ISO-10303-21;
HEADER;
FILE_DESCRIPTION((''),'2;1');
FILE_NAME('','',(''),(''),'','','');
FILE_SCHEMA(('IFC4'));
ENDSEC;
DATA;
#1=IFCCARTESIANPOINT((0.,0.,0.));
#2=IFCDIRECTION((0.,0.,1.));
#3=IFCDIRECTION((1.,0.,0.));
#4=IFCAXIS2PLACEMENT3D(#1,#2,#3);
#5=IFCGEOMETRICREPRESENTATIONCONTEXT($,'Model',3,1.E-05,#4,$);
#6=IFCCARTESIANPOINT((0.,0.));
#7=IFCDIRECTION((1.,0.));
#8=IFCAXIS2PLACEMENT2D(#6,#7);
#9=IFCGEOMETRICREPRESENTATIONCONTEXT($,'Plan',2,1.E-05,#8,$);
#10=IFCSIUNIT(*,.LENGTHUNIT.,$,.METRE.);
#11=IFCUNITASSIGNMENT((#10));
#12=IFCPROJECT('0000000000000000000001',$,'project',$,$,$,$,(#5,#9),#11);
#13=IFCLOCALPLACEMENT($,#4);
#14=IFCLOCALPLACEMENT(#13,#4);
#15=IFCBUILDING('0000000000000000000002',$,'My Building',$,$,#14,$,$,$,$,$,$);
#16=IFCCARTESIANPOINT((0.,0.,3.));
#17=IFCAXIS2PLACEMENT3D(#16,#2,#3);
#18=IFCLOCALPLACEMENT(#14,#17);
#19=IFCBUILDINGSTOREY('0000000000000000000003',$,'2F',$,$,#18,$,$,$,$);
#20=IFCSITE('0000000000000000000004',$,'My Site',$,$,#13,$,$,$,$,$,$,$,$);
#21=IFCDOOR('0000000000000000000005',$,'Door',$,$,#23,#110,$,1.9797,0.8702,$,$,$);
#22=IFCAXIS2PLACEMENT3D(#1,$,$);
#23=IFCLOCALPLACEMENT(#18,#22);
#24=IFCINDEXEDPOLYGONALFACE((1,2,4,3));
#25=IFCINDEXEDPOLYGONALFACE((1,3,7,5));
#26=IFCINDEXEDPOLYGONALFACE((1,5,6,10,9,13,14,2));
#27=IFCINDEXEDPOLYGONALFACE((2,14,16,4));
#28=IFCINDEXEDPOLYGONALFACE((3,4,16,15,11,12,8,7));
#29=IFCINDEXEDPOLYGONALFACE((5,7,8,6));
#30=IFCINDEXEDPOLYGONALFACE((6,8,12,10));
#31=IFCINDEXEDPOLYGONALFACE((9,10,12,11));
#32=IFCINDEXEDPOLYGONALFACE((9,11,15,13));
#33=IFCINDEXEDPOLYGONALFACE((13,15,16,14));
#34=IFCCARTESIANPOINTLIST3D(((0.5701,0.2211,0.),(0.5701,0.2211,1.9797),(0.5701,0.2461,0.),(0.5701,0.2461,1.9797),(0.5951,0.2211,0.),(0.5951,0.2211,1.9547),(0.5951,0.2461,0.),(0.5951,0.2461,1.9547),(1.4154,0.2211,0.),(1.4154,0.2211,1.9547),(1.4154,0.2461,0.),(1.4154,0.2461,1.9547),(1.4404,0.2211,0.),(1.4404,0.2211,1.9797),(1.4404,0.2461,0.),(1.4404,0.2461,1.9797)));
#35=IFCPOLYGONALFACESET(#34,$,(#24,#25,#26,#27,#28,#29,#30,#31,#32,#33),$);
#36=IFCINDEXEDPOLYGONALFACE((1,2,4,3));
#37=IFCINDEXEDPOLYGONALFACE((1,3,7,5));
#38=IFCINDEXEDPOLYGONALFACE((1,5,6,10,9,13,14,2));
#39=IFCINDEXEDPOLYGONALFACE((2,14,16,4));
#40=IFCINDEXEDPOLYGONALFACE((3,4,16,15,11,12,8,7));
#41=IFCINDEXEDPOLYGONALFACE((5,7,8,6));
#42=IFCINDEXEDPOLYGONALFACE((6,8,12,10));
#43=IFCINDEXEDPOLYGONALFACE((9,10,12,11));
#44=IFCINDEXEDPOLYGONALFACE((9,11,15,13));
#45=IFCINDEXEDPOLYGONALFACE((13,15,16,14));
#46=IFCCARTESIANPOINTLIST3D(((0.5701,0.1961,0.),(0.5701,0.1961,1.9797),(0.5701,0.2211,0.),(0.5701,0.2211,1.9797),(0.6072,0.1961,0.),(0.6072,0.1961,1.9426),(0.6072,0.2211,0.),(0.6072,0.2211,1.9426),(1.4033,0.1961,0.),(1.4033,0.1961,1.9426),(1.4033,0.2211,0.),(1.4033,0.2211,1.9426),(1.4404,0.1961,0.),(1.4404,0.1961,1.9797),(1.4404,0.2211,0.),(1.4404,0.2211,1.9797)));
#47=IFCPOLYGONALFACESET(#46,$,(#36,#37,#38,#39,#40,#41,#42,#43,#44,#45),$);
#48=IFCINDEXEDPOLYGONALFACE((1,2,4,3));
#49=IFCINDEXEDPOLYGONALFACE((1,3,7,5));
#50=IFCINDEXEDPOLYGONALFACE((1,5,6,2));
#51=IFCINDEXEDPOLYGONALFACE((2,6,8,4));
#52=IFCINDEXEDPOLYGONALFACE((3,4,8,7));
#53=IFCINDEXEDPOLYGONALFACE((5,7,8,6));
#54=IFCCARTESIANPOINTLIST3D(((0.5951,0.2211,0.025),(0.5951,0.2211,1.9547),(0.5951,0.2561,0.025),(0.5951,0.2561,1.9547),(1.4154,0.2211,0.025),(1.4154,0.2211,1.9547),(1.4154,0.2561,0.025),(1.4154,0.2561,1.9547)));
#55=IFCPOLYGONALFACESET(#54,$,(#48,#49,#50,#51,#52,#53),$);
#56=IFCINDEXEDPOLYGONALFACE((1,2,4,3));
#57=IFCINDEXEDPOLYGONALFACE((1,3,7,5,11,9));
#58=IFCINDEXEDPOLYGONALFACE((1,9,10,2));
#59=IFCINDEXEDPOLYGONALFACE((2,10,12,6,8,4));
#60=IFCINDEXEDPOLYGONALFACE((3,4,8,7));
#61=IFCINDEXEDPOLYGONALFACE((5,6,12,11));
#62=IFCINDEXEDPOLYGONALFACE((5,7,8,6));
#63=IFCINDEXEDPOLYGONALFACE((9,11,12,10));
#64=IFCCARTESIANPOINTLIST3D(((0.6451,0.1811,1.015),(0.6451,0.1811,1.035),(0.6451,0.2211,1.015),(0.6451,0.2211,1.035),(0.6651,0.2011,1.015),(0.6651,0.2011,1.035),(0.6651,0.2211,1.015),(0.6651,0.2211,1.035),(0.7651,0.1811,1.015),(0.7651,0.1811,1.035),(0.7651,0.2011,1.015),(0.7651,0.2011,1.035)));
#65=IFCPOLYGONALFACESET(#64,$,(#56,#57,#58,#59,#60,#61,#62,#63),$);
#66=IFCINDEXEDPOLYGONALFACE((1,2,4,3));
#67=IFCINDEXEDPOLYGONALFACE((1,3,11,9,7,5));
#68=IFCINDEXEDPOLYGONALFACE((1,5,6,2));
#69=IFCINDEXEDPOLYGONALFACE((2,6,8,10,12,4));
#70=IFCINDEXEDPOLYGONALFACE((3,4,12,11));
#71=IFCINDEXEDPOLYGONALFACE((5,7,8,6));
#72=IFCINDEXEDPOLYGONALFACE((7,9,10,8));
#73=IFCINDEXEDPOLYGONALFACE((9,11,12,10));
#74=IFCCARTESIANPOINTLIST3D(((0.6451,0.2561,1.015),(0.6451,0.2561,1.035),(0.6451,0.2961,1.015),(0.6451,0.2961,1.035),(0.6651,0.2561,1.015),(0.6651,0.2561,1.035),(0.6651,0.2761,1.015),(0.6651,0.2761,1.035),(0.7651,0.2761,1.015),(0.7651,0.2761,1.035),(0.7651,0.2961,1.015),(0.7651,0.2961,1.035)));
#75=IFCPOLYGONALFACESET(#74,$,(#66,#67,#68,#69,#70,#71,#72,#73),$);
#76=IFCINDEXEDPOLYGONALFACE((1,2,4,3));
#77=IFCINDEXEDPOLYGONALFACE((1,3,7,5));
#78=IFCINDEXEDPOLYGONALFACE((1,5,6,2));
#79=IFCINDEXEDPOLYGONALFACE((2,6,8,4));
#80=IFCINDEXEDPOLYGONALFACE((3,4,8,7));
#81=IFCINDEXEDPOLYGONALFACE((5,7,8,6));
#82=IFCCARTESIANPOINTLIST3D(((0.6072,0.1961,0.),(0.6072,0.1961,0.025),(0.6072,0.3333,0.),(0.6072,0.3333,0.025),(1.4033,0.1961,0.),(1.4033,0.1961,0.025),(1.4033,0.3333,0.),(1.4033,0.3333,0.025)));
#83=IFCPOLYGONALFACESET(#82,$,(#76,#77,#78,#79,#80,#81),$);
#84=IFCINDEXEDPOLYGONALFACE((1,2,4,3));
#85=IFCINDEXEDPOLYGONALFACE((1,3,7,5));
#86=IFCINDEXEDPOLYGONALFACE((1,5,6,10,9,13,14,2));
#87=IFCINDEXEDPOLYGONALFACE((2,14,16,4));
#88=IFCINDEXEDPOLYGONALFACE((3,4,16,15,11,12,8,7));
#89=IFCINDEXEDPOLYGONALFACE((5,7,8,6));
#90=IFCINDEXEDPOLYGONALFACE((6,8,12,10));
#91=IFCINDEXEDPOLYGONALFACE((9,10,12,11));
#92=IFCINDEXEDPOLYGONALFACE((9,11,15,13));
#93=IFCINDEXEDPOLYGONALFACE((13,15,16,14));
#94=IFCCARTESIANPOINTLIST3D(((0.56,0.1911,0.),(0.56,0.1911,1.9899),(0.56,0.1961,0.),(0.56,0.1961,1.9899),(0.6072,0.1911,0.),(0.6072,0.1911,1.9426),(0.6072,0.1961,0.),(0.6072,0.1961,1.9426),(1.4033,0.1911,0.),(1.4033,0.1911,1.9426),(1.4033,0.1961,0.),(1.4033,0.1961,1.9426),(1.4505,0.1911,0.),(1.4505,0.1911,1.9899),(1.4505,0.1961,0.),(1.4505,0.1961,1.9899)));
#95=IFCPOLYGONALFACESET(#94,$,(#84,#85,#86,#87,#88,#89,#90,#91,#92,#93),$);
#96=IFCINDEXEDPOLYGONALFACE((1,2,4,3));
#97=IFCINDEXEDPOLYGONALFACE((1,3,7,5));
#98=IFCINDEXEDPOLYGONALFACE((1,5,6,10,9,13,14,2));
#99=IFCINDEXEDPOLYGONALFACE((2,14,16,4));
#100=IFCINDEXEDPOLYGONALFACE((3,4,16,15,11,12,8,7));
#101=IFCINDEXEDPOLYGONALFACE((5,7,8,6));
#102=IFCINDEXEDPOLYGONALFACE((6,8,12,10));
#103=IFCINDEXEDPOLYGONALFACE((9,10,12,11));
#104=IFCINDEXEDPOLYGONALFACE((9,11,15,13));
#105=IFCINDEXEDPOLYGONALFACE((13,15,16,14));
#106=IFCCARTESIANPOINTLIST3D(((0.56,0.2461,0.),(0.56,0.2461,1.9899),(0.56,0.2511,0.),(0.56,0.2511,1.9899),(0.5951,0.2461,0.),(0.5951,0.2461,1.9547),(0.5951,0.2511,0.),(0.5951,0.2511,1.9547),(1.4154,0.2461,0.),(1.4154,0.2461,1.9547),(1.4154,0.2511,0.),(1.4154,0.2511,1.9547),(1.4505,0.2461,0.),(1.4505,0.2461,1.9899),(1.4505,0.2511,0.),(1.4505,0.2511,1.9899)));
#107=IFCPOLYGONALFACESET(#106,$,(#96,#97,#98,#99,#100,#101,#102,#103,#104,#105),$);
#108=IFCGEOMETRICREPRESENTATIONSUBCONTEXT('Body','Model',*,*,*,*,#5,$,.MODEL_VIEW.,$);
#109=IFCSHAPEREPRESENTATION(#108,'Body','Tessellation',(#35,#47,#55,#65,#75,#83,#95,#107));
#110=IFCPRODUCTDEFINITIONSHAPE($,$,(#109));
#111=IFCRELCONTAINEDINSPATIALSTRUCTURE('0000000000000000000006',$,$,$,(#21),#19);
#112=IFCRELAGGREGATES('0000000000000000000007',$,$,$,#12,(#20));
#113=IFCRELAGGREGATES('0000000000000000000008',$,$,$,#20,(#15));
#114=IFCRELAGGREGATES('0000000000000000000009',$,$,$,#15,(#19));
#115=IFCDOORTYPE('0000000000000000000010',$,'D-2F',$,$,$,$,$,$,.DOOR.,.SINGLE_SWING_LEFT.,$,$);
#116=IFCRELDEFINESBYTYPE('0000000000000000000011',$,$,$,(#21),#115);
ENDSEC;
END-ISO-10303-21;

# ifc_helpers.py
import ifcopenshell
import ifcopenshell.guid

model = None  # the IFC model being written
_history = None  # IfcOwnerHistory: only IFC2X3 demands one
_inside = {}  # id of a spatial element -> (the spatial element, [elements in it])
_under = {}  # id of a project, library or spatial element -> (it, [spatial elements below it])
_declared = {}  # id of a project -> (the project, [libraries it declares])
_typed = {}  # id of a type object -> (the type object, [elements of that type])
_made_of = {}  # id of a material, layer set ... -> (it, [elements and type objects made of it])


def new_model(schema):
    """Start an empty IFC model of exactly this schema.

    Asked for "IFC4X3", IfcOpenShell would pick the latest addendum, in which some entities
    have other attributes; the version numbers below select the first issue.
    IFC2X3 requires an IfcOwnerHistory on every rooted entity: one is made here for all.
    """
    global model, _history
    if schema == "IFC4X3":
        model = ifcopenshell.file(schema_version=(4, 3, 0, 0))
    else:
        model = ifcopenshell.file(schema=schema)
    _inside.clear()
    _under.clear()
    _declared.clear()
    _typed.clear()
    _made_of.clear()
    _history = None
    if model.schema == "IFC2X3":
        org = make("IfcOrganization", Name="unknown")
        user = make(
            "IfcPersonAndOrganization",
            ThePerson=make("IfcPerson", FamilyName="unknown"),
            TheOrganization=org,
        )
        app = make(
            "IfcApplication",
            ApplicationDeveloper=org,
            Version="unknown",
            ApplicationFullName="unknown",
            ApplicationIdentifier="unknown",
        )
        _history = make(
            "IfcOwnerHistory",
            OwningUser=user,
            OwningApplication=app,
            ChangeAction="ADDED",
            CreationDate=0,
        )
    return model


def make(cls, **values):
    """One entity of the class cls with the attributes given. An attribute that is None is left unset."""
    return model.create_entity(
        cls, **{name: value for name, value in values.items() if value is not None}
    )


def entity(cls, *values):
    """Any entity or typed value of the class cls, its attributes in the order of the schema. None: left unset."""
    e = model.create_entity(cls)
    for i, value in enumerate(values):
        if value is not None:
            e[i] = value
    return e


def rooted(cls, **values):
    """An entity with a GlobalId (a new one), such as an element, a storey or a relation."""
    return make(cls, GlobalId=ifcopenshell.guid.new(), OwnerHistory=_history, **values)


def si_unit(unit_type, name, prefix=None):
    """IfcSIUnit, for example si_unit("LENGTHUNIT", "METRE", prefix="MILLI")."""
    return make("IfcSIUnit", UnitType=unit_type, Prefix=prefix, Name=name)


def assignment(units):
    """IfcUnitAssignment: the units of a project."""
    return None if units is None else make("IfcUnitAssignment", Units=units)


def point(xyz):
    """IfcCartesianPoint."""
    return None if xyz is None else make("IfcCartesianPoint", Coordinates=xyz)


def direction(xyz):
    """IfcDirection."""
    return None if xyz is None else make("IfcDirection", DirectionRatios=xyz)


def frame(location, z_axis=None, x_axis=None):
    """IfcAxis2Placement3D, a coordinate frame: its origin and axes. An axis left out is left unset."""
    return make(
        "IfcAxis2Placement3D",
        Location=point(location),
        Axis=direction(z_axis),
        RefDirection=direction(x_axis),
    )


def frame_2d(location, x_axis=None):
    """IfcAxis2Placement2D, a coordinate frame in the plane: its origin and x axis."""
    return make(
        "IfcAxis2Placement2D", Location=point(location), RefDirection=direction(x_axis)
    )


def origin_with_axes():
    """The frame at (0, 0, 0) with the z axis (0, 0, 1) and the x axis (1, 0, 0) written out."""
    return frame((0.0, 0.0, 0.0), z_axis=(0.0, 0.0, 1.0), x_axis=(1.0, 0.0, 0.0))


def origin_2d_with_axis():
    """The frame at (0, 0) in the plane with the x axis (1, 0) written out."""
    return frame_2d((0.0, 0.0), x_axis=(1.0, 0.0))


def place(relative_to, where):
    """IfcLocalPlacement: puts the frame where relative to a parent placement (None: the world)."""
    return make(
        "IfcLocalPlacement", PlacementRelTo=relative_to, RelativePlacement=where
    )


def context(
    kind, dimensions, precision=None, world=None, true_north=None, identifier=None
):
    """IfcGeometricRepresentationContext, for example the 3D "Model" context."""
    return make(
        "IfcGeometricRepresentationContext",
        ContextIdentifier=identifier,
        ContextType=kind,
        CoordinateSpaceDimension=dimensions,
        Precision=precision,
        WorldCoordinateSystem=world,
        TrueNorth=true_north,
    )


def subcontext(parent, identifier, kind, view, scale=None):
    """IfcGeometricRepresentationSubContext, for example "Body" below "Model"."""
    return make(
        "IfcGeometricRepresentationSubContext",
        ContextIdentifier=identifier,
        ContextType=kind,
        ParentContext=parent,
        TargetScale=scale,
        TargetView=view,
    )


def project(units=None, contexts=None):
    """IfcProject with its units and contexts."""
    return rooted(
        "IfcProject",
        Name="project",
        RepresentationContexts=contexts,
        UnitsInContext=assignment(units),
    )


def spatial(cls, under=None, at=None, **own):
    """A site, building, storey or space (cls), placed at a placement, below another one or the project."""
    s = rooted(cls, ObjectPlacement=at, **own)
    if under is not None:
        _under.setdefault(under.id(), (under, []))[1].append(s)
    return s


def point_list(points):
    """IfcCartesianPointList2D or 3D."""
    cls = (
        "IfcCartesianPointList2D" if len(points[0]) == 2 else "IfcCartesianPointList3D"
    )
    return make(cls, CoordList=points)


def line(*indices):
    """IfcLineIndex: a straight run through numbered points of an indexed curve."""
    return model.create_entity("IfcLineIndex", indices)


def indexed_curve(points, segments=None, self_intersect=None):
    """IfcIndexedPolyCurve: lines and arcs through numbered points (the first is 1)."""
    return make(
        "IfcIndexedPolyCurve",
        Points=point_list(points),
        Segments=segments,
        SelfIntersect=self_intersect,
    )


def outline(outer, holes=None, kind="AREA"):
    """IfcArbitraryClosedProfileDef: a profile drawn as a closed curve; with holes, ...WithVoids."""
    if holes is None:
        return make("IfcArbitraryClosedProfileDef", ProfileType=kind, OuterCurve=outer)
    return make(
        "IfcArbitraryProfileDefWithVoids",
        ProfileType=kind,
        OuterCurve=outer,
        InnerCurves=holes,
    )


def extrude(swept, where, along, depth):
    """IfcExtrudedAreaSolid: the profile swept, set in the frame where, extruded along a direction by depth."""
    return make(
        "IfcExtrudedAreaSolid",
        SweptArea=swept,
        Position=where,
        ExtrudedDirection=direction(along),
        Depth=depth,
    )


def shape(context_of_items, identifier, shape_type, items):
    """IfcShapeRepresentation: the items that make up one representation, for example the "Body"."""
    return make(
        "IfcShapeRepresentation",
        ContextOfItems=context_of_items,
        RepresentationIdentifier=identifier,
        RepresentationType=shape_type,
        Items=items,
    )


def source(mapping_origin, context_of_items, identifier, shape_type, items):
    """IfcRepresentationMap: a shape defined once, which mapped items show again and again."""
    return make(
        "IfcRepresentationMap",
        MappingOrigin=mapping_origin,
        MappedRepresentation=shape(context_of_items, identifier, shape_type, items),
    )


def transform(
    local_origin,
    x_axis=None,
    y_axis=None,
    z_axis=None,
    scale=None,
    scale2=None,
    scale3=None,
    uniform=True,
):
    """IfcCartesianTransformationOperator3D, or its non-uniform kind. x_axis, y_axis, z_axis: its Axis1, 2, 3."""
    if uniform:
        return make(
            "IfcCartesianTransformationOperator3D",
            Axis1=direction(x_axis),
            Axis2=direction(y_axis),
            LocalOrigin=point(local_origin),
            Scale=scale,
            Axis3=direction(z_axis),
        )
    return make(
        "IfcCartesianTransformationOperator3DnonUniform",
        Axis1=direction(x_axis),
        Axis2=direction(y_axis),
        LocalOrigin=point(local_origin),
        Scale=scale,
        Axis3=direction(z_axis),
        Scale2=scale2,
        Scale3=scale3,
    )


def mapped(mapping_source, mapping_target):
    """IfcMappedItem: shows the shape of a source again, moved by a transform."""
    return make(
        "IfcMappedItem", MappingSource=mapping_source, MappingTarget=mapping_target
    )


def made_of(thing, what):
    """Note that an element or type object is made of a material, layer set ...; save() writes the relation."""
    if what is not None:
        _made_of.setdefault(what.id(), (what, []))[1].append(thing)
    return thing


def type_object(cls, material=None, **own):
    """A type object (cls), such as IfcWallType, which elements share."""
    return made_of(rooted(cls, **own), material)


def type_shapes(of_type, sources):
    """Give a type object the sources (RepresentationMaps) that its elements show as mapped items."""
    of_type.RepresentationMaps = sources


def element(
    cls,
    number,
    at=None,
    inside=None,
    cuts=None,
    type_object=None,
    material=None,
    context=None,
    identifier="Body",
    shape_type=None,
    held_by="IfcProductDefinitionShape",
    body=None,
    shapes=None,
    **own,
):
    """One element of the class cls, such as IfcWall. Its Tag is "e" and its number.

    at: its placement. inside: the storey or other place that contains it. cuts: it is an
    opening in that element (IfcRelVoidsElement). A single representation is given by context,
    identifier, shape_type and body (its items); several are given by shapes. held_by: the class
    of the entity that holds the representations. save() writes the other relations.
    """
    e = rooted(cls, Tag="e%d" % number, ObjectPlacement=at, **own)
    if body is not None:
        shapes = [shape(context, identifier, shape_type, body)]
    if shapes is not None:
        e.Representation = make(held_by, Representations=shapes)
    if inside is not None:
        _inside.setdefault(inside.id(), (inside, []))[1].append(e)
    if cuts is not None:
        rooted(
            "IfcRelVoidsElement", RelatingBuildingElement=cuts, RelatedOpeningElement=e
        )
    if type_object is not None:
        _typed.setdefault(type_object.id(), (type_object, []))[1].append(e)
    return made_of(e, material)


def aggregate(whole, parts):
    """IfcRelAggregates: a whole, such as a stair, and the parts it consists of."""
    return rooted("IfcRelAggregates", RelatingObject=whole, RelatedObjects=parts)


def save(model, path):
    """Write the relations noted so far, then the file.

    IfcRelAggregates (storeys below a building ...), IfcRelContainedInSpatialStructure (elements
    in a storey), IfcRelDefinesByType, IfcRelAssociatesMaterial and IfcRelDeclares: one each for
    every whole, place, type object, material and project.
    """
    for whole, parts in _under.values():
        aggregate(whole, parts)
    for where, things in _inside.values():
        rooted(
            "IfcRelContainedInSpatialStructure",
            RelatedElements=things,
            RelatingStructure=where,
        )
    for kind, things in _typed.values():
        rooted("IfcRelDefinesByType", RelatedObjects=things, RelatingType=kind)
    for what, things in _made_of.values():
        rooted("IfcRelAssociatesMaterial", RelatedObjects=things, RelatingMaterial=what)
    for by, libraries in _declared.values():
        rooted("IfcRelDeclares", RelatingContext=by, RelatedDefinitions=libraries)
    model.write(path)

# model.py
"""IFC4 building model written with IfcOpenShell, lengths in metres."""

from ifc_helpers import new_model, entity, si_unit, frame, origin_with_axes, origin_2d_with_axis, place, context, subcontext, project, spatial, line, indexed_curve, outline, extrude, shape, source, transform, mapped, type_object, type_shapes, element, save


model = new_model("IFC4")

# Units and contexts
model_context = context("Model", 3, precision=1e-05, world=origin_with_axes())
plan_context = context("Plan", 2, precision=1e-05, world=origin_2d_with_axis())
body_context_1 = subcontext(model_context, "Body", "Model", "MODEL_VIEW")
body_context_2 = subcontext(plan_context, "Body", "Plan", "PLAN_VIEW")
ifc_project = project(units=[si_unit("LENGTHUNIT", "METRE")], contexts=[model_context, plan_context])

# Site, building, storey
site_placement = place(None, origin_with_axes())
site = spatial("IfcSite", under=ifc_project, at=site_placement, Name="My Site")
building_placement = place(site_placement, origin_with_axes())
building = spatial("IfcBuilding", under=site, at=building_placement, Name="My Building")
storey_placement = place(building_placement, frame((0.0, 0.0, 3.0), z_axis=(0.0, 0.0, 1.0), x_axis=(1.0, 0.0, 0.0)))
storey = spatial("IfcBuildingStorey", under=building, at=storey_placement, Name="2F")

# Shared definitions
door_type_1 = type_object("IfcDoorType", Name="D-2F", OperationType="SINGLE_SWING_LEFT", PredefinedType="DOOR")
shared_shape_1 = source(origin_with_axes(), body_context_1, "Body", "SweptSolid", [
    extrude(outline(indexed_curve([(0.0, 0.0), (0.0, 1.9797), (0.8702, 1.9797), (0.8702, 0.0), (0.8452, 0.0), (0.8452, 1.9547), (0.025, 1.9547), (0.025, 0.0)], segments=[line(1, 2, 3, 4, 5, 6, 7, 8, 1)])), frame((0.0, 0.025, 0.0), z_axis=(0.0, -1.0, 0.0), x_axis=(1.0, 0.0, 0.0)), (0.0, 0.0, -1.0), 0.025),
    extrude(outline(indexed_curve([(0.0, 0.0), (0.0, 1.9797), (0.8702, 1.9797), (0.8702, 0.0), (0.8332, 0.0), (0.8332, 1.9426), (0.0371, 1.9426), (0.0371, 0.0)], segments=[line(1, 2, 3, 4, 5, 6, 7, 8, 1)])), frame((0.0, 0.0, 0.0), z_axis=(0.0, -1.0, 0.0), x_axis=(1.0, 0.0, 0.0)), (0.0, 0.0, -1.0), 0.025),
    extrude(outline(indexed_curve([(0.0, 0.0), (0.8202, 0.0), (0.8202, 0.035), (0.0, 0.035)], segments=[line(1, 2, 3, 4, 1)])), frame((0.025, 0.025, 0.025), z_axis=(0.0, 0.0, 1.0), x_axis=(1.0, 0.0, 0.0)), (0.0, 0.0, 1.0), 1.9297),
    extrude(outline(indexed_curve([(0.0, 0.0), (0.0, -0.04), (0.12, -0.04), (0.12, -0.02), (0.02, -0.02), (0.02, 0.0)], segments=[line(1, 2, 3, 4, 5, 6, 1)])), frame((0.075, 0.025, 1.015), z_axis=(0.0, 0.0, 1.0), x_axis=(1.0, 0.0, 0.0)), (0.0, 0.0, 1.0), 0.02),
    extrude(outline(indexed_curve([(0.0, 0.0), (0.0, 0.04), (0.12, 0.04), (0.12, 0.02), (0.02, 0.02), (0.02, 0.0)], segments=[line(1, 2, 3, 4, 5, 6, 1)])), frame((0.075, 0.06, 1.015), z_axis=(0.0, 0.0, 1.0), x_axis=(1.0, 0.0, 0.0)), (0.0, 0.0, 1.0), 0.02),
    extrude(outline(indexed_curve([(0.0, 0.0), (0.7961, 0.0), (0.7961, 0.1372), (0.0, 0.1372)], segments=[line(1, 2, 3, 4, 1)])), frame((0.0371, 0.0, 0.0), z_axis=(0.0, 0.0, 1.0), x_axis=(1.0, 0.0, 0.0)), (0.0, 0.0, 1.0), 0.025),
    extrude(outline(indexed_curve([(0.0, 0.0), (0.0, 1.9899), (0.8906, 1.9899), (0.8906, 0.0), (0.8433, 0.0), (0.8433, 1.9426), (0.0473, 1.9426), (0.0473, 0.0)], segments=[line(1, 2, 3, 4, 5, 6, 7, 8, 1)])), frame((-0.0102, -0.005, 0.0), z_axis=(0.0, -1.0, 0.0), x_axis=(1.0, 0.0, 0.0)), (0.0, 0.0, -1.0), 0.005),
    extrude(outline(indexed_curve([(0.0, 0.0), (0.0, 1.9899), (0.8906, 1.9899), (0.8906, 0.0), (0.8554, 0.0), (0.8554, 1.9547), (0.0352, 1.9547), (0.0352, 0.0)], segments=[line(1, 2, 3, 4, 5, 6, 7, 8, 1)])), frame((-0.0102, 0.05, 0.0), z_axis=(0.0, -1.0, 0.0), x_axis=(1.0, 0.0, 0.0)), (0.0, 0.0, -1.0), 0.005),
])
shared_shape_2 = source(origin_with_axes(), body_context_2, "Body", "Curve2D", [
    entity("IfcIndexedPolyCurve", entity("IfcCartesianPointList2D", [[0.0, 0.0], [0.0, 0.05], [0.025, 0.05], [0.025, 0.025], [0.0371, 0.025], [0.0371, 0.0]]), [entity("IfcLineIndex", [1, 2, 3, 4, 5, 6, 1])]),
    entity("IfcIndexedPolyCurve", entity("IfcCartesianPointList2D", [[0.8702, 0.0], [0.8702, 0.05], [0.8452, 0.05], [0.8452, 0.025], [0.8332, 0.025], [0.8332, 0.0]]), [entity("IfcLineIndex", [1, 2, 3, 4, 5, 6, 1])]),
    entity("IfcTrimmedCurve", entity("IfcEllipse", entity("IfcAxis2Placement2D", entity("IfcCartesianPoint", [0.8102, 0.05]), entity("IfcDirection", [1.0, 0.0])), 0.7852, 0.8202), [entity("IfcCartesianPoint", [0.8102, 0.8702])], [entity("IfcCartesianPoint", [0.025, 0.05])], True, "CARTESIAN"),
    entity("IfcIndexedPolyCurve", entity("IfcCartesianPointList2D", [[0.8452, 0.05], [0.8102, 0.05], [0.8102, 0.8702], [0.8452, 0.8702]]), [entity("IfcLineIndex", [1, 2, 3, 4, 1])]),
])
type_shapes(door_type_1, [shared_shape_1, shared_shape_2])

# Door
door_1_placement = place(storey_placement, frame((0.5701, 0.1961, 0.0), z_axis=(0.0, 0.0, 1.0), x_axis=(1.0, 0.0, 0.0)))
element("IfcDoor", 1, at=door_1_placement, inside=storey, type_object=door_type_1, Name="Door", OverallHeight=1.9797, OverallWidth=0.8702, shapes=[
    shape(body_context_1, "Body", "MappedRepresentation", [mapped(shared_shape_1, transform((0.0, 0.0, 0.0), x_axis=(1.0, 0.0, 0.0), y_axis=(0.0, 1.0, 0.0), z_axis=(0.0, 0.0, 1.0), scale=1.0))]),
    shape(body_context_2, "Body", "MappedRepresentation", [mapped(shared_shape_2, transform((0.0, 0.0, 0.0), x_axis=(1.0, 0.0, 0.0), y_axis=(0.0, 1.0, 0.0), z_axis=(0.0, 0.0, 1.0), scale=1.0))]),
])

save(model, "model.ifc")
